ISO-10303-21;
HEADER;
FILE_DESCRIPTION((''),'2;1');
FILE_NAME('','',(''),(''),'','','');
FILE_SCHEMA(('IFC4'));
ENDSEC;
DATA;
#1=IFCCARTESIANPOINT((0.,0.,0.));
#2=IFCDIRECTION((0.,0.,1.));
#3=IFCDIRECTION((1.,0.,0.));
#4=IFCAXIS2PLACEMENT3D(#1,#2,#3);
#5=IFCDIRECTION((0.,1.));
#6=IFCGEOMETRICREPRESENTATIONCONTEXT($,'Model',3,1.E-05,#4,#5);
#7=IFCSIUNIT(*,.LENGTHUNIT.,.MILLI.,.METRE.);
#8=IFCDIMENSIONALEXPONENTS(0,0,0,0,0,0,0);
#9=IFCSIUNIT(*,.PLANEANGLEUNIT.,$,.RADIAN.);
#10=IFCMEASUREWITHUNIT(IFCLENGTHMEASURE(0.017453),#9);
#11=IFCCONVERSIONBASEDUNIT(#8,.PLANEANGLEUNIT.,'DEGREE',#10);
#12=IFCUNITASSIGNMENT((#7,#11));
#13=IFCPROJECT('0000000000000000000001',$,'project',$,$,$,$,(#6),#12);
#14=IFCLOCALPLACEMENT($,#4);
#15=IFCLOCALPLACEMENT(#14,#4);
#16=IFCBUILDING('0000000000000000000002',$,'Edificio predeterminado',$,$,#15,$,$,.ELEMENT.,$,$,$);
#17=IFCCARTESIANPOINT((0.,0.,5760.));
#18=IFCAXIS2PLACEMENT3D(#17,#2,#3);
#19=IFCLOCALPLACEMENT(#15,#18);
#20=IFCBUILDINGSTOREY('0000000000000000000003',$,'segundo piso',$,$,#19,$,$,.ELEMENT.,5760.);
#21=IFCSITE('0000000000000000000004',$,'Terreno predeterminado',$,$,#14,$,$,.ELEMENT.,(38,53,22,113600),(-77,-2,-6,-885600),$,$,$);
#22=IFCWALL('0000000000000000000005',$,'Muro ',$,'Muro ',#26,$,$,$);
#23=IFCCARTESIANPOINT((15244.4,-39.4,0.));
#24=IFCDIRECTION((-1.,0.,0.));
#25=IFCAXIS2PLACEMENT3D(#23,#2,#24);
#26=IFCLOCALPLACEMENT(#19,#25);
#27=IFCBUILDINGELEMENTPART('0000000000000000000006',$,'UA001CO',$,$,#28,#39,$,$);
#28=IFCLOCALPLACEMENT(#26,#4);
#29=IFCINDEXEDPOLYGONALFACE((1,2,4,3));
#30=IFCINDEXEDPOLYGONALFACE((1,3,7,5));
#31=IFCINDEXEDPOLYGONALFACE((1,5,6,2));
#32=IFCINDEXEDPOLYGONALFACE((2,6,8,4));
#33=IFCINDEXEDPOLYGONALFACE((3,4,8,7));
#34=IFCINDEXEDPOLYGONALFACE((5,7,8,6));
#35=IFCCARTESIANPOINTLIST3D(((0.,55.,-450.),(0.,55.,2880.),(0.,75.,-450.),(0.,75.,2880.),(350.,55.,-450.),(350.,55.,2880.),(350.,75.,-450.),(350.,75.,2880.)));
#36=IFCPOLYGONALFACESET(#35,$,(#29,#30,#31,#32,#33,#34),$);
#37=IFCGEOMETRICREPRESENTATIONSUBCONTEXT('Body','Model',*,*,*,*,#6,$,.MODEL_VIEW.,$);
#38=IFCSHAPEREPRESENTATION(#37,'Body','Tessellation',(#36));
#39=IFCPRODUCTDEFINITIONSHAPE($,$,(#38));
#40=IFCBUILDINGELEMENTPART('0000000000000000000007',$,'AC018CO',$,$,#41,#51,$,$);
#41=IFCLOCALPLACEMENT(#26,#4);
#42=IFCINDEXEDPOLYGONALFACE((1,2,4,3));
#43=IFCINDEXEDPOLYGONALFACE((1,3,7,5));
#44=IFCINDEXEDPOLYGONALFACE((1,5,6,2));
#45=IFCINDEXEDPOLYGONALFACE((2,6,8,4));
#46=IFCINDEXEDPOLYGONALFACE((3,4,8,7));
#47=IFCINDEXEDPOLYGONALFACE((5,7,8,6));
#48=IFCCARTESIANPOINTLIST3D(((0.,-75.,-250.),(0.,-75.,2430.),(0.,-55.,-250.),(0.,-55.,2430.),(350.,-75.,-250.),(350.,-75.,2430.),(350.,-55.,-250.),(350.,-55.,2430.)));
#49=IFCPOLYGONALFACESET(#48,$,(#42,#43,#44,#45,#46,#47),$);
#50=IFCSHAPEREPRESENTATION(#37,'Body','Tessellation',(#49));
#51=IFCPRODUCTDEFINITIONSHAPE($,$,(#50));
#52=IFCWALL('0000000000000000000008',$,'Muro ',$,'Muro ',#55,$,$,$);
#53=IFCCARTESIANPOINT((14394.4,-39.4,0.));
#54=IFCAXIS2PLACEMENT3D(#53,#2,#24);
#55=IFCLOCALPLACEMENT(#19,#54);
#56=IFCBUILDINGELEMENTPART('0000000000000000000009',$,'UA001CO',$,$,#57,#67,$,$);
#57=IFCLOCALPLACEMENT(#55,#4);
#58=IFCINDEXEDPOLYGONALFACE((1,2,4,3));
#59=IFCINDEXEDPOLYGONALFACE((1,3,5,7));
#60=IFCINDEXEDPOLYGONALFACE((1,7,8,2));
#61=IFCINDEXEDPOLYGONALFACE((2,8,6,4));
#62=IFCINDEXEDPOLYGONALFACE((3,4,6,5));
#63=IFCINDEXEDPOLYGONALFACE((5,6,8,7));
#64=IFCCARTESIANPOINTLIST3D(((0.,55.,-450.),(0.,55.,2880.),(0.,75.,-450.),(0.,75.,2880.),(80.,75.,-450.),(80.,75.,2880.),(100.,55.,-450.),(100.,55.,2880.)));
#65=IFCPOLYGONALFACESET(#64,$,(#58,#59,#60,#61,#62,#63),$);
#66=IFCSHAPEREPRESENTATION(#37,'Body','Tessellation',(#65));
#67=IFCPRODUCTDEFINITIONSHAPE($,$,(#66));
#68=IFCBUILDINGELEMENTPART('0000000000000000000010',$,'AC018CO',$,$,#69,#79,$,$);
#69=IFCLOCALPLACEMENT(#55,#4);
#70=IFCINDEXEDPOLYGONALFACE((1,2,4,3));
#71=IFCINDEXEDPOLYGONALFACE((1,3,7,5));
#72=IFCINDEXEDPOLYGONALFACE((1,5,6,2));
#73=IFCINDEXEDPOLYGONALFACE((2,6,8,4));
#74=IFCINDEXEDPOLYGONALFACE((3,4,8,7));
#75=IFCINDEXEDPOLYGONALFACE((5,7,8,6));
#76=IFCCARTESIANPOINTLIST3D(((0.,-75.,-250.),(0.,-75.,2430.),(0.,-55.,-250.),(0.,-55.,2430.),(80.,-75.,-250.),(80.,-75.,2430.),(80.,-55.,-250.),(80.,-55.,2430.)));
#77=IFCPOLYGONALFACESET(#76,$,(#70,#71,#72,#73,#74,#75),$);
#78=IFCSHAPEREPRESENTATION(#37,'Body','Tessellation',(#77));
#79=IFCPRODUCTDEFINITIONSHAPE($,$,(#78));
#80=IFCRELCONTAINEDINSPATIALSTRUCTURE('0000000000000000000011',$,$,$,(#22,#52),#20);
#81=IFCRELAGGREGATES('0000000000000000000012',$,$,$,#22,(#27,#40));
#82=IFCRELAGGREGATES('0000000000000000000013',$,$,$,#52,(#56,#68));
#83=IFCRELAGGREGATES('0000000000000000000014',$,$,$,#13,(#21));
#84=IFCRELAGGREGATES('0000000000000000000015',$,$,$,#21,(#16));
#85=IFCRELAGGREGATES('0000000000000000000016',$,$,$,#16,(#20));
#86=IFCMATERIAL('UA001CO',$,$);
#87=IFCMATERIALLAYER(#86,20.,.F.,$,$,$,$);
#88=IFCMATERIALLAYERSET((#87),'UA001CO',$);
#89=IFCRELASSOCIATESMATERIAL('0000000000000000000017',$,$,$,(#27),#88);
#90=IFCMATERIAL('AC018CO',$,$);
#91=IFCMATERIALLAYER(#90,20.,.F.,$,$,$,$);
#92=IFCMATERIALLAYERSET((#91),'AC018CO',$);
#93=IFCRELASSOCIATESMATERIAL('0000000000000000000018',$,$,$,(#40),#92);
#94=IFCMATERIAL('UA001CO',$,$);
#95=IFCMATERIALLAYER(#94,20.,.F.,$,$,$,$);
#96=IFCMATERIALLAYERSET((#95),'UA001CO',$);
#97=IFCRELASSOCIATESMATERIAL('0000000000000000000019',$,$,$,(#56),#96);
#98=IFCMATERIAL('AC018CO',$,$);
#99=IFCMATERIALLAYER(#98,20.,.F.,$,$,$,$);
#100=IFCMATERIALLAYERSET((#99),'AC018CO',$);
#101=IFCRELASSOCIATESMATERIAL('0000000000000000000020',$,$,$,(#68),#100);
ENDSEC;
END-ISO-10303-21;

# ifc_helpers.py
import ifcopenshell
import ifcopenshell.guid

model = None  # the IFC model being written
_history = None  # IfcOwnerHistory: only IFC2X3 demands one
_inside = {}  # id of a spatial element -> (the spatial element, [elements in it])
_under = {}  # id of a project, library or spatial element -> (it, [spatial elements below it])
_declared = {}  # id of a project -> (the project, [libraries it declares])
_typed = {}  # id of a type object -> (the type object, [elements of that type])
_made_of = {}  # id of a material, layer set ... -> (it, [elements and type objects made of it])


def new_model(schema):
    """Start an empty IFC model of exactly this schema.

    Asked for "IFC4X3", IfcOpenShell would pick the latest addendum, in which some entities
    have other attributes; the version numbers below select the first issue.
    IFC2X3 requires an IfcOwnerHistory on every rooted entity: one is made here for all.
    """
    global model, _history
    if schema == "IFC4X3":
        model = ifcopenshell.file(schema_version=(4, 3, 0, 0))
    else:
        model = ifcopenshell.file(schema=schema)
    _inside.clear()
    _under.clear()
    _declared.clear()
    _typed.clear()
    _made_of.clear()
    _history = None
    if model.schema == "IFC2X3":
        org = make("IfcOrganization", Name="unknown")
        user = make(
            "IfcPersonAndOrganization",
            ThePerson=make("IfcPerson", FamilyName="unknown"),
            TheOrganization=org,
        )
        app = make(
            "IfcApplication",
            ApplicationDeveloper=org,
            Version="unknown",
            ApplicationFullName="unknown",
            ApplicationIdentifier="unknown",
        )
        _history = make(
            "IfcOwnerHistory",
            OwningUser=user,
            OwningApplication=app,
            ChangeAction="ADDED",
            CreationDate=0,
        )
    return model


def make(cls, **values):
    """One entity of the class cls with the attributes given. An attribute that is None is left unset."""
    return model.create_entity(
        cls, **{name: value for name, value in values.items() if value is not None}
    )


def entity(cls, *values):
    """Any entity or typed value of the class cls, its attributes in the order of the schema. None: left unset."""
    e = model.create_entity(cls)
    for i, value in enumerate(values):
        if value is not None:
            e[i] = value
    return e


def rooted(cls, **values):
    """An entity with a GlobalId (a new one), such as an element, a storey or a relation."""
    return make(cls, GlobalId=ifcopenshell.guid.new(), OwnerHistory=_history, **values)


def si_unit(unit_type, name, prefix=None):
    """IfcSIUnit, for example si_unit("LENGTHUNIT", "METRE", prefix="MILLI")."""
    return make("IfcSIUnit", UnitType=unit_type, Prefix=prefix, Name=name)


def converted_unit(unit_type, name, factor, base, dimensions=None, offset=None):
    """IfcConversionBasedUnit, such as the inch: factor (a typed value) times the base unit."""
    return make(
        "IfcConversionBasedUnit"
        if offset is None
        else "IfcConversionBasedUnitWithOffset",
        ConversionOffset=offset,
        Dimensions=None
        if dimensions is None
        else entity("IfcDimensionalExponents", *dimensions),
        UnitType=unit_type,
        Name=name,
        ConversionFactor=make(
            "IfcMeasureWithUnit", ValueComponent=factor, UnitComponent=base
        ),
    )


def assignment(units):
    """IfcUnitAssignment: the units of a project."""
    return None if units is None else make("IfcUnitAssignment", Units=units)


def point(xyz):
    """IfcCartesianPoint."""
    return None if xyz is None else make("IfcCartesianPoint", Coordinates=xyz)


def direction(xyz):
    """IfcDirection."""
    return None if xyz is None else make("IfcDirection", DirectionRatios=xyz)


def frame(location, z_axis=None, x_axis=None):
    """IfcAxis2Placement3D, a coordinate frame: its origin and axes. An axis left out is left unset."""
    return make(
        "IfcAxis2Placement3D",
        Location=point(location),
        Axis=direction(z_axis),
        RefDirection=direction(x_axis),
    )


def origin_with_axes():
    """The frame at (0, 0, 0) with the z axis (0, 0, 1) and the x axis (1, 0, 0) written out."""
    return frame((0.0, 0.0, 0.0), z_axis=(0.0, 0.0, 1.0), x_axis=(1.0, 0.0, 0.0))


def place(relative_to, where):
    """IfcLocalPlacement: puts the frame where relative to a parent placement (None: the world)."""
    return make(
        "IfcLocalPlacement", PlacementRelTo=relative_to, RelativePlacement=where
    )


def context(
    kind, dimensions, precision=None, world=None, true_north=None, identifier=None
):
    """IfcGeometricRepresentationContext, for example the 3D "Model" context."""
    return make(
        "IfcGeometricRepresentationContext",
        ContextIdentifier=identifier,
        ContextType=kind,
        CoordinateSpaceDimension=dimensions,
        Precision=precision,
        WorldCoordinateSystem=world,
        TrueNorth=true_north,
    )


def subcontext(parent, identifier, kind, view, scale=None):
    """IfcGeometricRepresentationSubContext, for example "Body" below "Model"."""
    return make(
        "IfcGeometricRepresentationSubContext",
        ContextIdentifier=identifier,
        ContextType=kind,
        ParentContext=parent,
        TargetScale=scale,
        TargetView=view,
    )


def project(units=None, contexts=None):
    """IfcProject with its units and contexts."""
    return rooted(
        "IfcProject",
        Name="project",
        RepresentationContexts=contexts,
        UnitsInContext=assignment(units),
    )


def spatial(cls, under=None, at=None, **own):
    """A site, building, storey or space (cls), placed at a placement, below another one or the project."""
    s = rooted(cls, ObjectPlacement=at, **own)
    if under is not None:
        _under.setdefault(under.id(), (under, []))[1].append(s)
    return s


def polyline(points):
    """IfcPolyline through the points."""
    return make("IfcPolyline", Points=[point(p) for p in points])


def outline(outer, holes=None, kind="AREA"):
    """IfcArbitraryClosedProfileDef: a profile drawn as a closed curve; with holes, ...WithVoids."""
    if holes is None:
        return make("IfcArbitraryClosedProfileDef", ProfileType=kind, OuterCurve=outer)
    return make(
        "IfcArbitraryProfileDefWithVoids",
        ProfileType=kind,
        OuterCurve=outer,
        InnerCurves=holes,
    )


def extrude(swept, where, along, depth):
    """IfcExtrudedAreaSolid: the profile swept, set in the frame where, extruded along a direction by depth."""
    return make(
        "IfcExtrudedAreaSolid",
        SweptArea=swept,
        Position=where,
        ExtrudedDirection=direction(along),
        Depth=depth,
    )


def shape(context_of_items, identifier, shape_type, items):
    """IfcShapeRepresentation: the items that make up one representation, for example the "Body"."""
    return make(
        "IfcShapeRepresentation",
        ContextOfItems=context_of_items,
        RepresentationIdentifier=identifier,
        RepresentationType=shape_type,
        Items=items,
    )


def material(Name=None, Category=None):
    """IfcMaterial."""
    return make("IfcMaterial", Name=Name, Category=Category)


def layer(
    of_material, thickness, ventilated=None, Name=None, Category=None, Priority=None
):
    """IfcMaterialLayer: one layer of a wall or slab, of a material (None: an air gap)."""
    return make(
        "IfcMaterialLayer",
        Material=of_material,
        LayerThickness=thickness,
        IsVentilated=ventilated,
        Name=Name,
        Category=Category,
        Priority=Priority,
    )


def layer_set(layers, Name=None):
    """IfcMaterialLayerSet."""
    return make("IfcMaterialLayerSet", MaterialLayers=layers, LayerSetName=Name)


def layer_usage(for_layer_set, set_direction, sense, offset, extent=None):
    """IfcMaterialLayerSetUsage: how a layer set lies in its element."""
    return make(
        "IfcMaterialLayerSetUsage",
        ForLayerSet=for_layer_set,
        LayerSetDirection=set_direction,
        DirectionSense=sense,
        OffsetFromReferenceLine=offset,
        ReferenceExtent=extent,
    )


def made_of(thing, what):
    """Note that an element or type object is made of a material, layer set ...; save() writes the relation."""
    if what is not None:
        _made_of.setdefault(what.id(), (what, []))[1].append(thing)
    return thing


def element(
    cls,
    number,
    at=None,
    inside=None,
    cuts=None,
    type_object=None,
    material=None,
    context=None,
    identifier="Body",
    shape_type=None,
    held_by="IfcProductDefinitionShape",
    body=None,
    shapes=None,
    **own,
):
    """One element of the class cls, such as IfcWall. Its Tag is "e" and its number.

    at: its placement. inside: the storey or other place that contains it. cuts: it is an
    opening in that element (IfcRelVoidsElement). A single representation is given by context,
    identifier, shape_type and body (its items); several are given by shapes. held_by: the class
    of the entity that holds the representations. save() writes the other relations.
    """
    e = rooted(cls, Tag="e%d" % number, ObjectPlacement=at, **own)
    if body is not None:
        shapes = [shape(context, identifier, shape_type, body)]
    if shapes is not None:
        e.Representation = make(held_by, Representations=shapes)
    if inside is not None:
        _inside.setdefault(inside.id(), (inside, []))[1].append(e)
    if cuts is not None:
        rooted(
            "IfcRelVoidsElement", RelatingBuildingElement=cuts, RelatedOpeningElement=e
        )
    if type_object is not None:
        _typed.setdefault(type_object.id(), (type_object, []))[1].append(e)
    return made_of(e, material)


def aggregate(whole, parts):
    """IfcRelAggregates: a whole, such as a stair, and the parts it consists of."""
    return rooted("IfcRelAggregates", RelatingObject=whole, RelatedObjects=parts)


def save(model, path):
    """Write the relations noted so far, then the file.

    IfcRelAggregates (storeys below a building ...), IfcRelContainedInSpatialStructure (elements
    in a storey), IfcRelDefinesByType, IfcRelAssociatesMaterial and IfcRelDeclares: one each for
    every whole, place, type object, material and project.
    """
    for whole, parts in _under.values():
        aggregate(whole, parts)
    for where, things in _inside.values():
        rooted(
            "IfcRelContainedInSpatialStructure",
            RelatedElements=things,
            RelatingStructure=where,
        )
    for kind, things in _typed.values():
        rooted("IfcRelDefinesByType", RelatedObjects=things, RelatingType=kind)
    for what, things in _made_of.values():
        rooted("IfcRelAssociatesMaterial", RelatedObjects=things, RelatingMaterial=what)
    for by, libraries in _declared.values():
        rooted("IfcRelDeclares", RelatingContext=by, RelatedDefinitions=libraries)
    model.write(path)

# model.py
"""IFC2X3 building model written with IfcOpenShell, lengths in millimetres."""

from ifc_helpers import new_model, entity, si_unit, converted_unit, direction, frame, origin_with_axes, place, context, subcontext, project, spatial, polyline, outline, extrude, material, layer, layer_set, layer_usage, element, aggregate, save


model = new_model("IFC2X3")

# Units and contexts
model_context = context("Model", 3, precision=1e-05, world=origin_with_axes(), true_north=direction((0.0, 1.0)))
body_context = subcontext(model_context, "Body", "Model", "MODEL_VIEW")
ifc_project = project(units=[si_unit("LENGTHUNIT", "METRE", prefix="MILLI"), converted_unit("PLANEANGLEUNIT", "DEGREE", entity("IfcLengthMeasure", 0.017453), si_unit("PLANEANGLEUNIT", "RADIAN"), dimensions=[0, 0, 0, 0, 0, 0, 0])], contexts=[model_context])

# Site, building, storey
site_placement = place(None, origin_with_axes())
site = spatial("IfcSite", under=ifc_project, at=site_placement, Name="Terreno predeterminado", CompositionType="ELEMENT", RefLatitude=(38, 53, 22, 113600), RefLongitude=(-77, -2, -6, -885600))
building_placement = place(site_placement, origin_with_axes())
building = spatial("IfcBuilding", under=site, at=building_placement, Name="Edificio predeterminado", CompositionType="ELEMENT")
storey_placement = place(building_placement, frame((0.0, 0.0, 5760.0), z_axis=(0.0, 0.0, 1.0), x_axis=(1.0, 0.0, 0.0)))
storey = spatial("IfcBuildingStorey", under=building, at=storey_placement, Name="segundo piso", CompositionType="ELEMENT", Elevation=5760.0)

# Walls, building element parts
wall_1_placement = place(storey_placement, frame((15244.4, -39.4, 0.0), z_axis=(0.0, 0.0, 1.0), x_axis=(-1.0, 0.0, 0.0)))
wall_1 = element("IfcWall", 1, at=wall_1_placement, inside=storey, Name="Muro ", ObjectType="Muro ")
ifc_material_1 = material(Name="UA001CO")
ifc_layer_1 = layer(ifc_material_1, 20.0, ventilated=False)
ifc_layer_set_1 = layer_set([ifc_layer_1], Name="UA001CO")
ifc_layer_usage_1 = layer_usage(ifc_layer_set_1, "AXIS2", "NEGATIVE", -75.0)
building_element_part_1_placement = place(wall_1_placement, origin_with_axes())
building_element_part_1 = element("IfcBuildingElementPart", 2, at=building_element_part_1_placement, material=ifc_layer_usage_1, Name="UA001CO", context=body_context, shape_type="SweptSolid", body=[
    extrude(outline(polyline([(350.0, 75.0), (350.0, 55.0), (0.0, 55.0), (0.0, 75.0), (350.0, 75.0)])), frame((0.0, 0.0, -450.0), z_axis=(0.0, 0.0, 1.0), x_axis=(1.0, 0.0, 0.0)), (0.0, 0.0, 1.0), 3330.0),
])
ifc_material_2 = material(Name="AC018CO")
ifc_layer_2 = layer(ifc_material_2, 20.0, ventilated=False)
ifc_layer_set_2 = layer_set([ifc_layer_2], Name="AC018CO")
ifc_layer_usage_2 = layer_usage(ifc_layer_set_2, "AXIS2", "NEGATIVE", 55.0)
building_element_part_2_placement = place(wall_1_placement, origin_with_axes())
building_element_part_2 = element("IfcBuildingElementPart", 3, at=building_element_part_2_placement, material=ifc_layer_usage_2, Name="AC018CO", context=body_context, shape_type="SweptSolid", body=[
    extrude(outline(polyline([(350.0, -55.0), (350.0, -75.0), (0.0, -75.0), (0.0, -55.0), (350.0, -55.0)])), frame((0.0, 0.0, -250.0), z_axis=(0.0, 0.0, 1.0), x_axis=(1.0, 0.0, 0.0)), (0.0, 0.0, 1.0), 2680.0),
])
aggregate(wall_1, [building_element_part_1, building_element_part_2])
wall_2_placement = place(storey_placement, frame((14394.4, -39.4, 0.0), z_axis=(0.0, 0.0, 1.0), x_axis=(-1.0, 0.0, 0.0)))
wall_2 = element("IfcWall", 4, at=wall_2_placement, inside=storey, Name="Muro ", ObjectType="Muro ")
ifc_material_3 = material(Name="UA001CO")
ifc_layer_3 = layer(ifc_material_3, 20.0, ventilated=False)
ifc_layer_set_3 = layer_set([ifc_layer_3], Name="UA001CO")
ifc_layer_usage_3 = layer_usage(ifc_layer_set_3, "AXIS2", "NEGATIVE", -75.0)
building_element_part_3_placement = place(wall_2_placement, origin_with_axes())
building_element_part_3 = element("IfcBuildingElementPart", 5, at=building_element_part_3_placement, material=ifc_layer_usage_3, Name="UA001CO", context=body_context, shape_type="SweptSolid", body=[
    extrude(outline(polyline([(80.0, 75.0), (100.0, 55.0), (0.0, 55.0), (0.0, 75.0), (80.0, 75.0)])), frame((0.0, 0.0, -450.0), z_axis=(0.0, 0.0, 1.0), x_axis=(1.0, 0.0, 0.0)), (0.0, 0.0, 1.0), 3330.0),
])
ifc_material_4 = material(Name="AC018CO")
ifc_layer_4 = layer(ifc_material_4, 20.0, ventilated=False)
ifc_layer_set_4 = layer_set([ifc_layer_4], Name="AC018CO")
ifc_layer_usage_4 = layer_usage(ifc_layer_set_4, "AXIS2", "NEGATIVE", 55.0)
building_element_part_4_placement = place(wall_2_placement, origin_with_axes())
building_element_part_4 = element("IfcBuildingElementPart", 6, at=building_element_part_4_placement, material=ifc_layer_usage_4, Name="AC018CO", context=body_context, shape_type="SweptSolid", body=[
    extrude(outline(polyline([(80.0, -55.0), (80.0, -75.0), (0.0, -75.0), (0.0, -55.0), (80.0, -55.0)])), frame((0.0, 0.0, -250.0), z_axis=(0.0, 0.0, 1.0), x_axis=(1.0, 0.0, 0.0)), (0.0, 0.0, 1.0), 2680.0),
])
aggregate(wall_2, [building_element_part_3, building_element_part_4])

save(model, "model.ifc")
